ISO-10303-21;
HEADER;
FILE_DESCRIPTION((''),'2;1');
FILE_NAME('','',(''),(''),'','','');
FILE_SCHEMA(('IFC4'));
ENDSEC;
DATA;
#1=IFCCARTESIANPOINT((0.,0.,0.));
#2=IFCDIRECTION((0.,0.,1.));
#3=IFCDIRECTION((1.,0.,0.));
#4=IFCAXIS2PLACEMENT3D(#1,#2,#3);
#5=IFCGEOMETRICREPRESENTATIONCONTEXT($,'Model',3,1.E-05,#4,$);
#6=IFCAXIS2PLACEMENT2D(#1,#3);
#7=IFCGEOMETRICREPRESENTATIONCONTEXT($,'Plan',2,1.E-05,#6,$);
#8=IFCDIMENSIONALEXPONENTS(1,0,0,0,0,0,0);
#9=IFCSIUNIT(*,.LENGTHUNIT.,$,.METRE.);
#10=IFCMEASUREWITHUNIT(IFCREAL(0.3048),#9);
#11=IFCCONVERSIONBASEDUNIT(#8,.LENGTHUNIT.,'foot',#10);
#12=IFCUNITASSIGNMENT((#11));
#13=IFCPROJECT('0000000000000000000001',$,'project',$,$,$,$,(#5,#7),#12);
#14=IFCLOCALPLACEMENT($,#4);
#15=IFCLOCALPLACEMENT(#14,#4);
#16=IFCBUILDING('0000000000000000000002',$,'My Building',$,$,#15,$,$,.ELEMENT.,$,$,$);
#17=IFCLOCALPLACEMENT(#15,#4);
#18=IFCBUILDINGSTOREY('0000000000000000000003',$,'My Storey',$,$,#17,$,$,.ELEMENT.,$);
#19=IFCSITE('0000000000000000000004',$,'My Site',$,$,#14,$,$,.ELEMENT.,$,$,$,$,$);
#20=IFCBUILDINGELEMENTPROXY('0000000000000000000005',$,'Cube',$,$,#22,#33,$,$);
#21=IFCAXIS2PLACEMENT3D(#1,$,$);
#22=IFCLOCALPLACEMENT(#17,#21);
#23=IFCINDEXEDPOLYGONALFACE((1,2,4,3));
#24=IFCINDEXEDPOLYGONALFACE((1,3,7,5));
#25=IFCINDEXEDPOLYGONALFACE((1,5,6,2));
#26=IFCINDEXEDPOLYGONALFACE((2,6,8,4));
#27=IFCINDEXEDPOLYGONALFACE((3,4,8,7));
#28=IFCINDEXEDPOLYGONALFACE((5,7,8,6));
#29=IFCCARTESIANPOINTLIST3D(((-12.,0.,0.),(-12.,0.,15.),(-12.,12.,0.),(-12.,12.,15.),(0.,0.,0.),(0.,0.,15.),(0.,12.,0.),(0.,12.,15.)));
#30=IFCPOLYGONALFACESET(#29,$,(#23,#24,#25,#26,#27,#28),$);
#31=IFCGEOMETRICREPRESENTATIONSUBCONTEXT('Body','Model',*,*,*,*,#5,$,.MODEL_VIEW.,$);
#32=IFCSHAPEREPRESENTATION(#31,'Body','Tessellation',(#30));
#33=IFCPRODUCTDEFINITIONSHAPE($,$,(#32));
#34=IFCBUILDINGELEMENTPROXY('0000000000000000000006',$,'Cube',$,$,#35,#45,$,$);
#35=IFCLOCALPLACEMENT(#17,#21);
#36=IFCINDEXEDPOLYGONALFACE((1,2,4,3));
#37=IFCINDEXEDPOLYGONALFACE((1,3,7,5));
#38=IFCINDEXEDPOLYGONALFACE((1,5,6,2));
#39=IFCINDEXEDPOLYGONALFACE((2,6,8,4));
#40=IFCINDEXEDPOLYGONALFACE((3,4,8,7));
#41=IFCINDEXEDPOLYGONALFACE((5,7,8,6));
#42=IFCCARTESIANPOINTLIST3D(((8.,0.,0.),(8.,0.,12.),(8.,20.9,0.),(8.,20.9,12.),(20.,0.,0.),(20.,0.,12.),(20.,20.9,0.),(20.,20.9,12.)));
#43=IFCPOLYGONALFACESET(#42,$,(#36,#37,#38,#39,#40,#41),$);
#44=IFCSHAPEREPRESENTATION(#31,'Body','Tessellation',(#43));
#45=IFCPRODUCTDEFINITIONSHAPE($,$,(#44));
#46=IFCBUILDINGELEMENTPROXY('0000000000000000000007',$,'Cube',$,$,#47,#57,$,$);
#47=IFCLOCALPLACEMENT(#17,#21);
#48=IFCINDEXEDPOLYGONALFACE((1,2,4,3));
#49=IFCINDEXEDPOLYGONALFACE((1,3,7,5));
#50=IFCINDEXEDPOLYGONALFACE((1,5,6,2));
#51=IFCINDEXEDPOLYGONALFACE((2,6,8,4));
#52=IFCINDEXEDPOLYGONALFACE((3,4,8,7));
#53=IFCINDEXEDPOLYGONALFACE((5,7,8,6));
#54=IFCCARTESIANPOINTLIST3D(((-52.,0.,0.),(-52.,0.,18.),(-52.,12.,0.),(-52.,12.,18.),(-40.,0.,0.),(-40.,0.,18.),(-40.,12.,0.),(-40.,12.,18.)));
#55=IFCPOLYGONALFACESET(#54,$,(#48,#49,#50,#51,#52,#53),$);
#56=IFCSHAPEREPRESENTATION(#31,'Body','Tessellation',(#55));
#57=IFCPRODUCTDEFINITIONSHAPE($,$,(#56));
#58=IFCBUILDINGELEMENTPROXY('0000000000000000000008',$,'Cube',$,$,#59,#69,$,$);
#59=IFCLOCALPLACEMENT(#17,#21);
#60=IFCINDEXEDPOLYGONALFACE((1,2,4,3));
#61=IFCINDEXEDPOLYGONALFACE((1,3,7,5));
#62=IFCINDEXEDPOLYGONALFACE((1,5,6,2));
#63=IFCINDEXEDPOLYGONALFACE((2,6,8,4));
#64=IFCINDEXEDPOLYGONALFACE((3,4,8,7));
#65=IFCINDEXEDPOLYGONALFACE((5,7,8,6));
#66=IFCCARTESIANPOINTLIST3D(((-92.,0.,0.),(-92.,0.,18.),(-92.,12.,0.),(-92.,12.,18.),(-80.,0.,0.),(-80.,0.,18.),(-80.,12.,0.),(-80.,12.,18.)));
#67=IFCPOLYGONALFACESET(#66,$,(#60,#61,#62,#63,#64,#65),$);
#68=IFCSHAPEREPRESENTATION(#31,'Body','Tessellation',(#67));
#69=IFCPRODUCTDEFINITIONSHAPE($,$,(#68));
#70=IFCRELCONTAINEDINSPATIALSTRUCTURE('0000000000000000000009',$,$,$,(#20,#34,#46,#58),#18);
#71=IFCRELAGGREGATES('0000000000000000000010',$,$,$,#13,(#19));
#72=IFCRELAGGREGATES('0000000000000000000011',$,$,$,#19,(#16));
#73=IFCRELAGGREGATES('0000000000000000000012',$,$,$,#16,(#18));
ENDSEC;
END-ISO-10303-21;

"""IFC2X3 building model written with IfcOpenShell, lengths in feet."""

from ifc_helpers import new_model, entity, si_unit, converted_unit, frame, frame_2d, origin_with_axes, place, context, subcontext, project, spatial, polyline, outline, extrude, element, save


model = new_model("IFC2X3")

# Units and contexts
model_context = context("Model", 3, precision=1e-05, world=origin_with_axes())
plan_context = context("Plan", 2, precision=1e-05, world=frame_2d((0.0, 0.0, 0.0), x_axis=(1.0, 0.0, 0.0)))
body_context = subcontext(model_context, "Body", "Model", "MODEL_VIEW")
ifc_project = project(units=[converted_unit("LENGTHUNIT", "foot", entity("IfcReal", 0.3048), si_unit("LENGTHUNIT", "METRE"), dimensions=[1, 0, 0, 0, 0, 0, 0])], contexts=[model_context, plan_context])

# Site, building, storey
site_placement = place(None, origin_with_axes())
site = spatial("IfcSite", under=ifc_project, at=site_placement, Name="My Site", CompositionType="ELEMENT")
building_placement = place(site_placement, origin_with_axes())
building = spatial("IfcBuilding", under=site, at=building_placement, Name="My Building", CompositionType="ELEMENT")
storey_placement = place(building_placement, origin_with_axes())
storey = spatial("IfcBuildingStorey", under=building, at=storey_placement, Name="My Storey", CompositionType="ELEMENT")

# Building element proxies
proxy_1_placement = place(storey_placement, origin_with_axes())
element("IfcBuildingElementProxy", 1, at=proxy_1_placement, inside=storey, Name="Cube", context=body_context, shape_type="SweptSolid", body=[
    extrude(outline(polyline([(-6.0, -6.0), (6.0, -6.0), (6.0, 6.0), (-6.0, 6.0), (-6.0, -6.0)])), frame((-6.0, 6.0, 0.0), z_axis=(0.0, 0.0, -1.0), x_axis=(-1.0, 0.0, 0.0)), (0.0, 0.0, -1.0), 15.0),
])
proxy_2_placement = place(storey_placement, frame((20.0, 0.0, 12.0), z_axis=(0.0, 1.0, 0.0), x_axis=(1.0, 0.0, 0.0)))
element("IfcBuildingElementProxy", 2, at=proxy_2_placement, inside=storey, Name="Cube", context=body_context, shape_type="SweptSolid", body=[
    extrude(outline(polyline([(-6.0, -6.0), (6.0, -6.0), (6.0, 6.0), (-6.0, 6.0), (-6.0, -6.0)])), frame((-6.0, 6.0, 0.0), z_axis=(0.0, 0.0, -1.0), x_axis=(-1.0, 0.0, 0.0)), (0.0, 0.0, -1.0), 20.9),
])
proxy_3_placement = place(storey_placement, frame((-40.0, 0.0, 0.0), z_axis=(0.0, 0.0, 1.0), x_axis=(1.0, 0.0, 0.0)))
element("IfcBuildingElementProxy", 3, at=proxy_3_placement, inside=storey, Name="Cube", context=body_context, shape_type="SweptSolid", body=[
    extrude(outline(polyline([(-6.0, -6.0), (6.0, -6.0), (6.0, 6.0), (-6.0, 6.0), (-6.0, -6.0)])), frame((-6.0, 6.0, 0.0), z_axis=(0.0, 0.0, -1.0), x_axis=(-1.0, 0.0, 0.0)), (0.0, 0.0, -1.0), 18.0),
])
proxy_4_placement = place(storey_placement, frame((-86.0, 6.0, 6.0), z_axis=(0.0, 0.0, 1.0), x_axis=(1.0, 0.0, 0.0)))
element("IfcBuildingElementProxy", 4, at=proxy_4_placement, inside=storey, Name="Cube", context=body_context, shape_type="SweptSolid", body=[
    extrude(outline(polyline([(-6.0, -6.0), (6.0, -6.0), (6.0, 6.0), (-6.0, 6.0), (-6.0, -6.0)])), frame((0.0, 0.0, -6.0), z_axis=(0.0, 0.0, -1.0), x_axis=(1.0, 0.0, 0.0)), (0.0, 0.0, -1.0), 18.0),
])

save(model, "model.ifc")
